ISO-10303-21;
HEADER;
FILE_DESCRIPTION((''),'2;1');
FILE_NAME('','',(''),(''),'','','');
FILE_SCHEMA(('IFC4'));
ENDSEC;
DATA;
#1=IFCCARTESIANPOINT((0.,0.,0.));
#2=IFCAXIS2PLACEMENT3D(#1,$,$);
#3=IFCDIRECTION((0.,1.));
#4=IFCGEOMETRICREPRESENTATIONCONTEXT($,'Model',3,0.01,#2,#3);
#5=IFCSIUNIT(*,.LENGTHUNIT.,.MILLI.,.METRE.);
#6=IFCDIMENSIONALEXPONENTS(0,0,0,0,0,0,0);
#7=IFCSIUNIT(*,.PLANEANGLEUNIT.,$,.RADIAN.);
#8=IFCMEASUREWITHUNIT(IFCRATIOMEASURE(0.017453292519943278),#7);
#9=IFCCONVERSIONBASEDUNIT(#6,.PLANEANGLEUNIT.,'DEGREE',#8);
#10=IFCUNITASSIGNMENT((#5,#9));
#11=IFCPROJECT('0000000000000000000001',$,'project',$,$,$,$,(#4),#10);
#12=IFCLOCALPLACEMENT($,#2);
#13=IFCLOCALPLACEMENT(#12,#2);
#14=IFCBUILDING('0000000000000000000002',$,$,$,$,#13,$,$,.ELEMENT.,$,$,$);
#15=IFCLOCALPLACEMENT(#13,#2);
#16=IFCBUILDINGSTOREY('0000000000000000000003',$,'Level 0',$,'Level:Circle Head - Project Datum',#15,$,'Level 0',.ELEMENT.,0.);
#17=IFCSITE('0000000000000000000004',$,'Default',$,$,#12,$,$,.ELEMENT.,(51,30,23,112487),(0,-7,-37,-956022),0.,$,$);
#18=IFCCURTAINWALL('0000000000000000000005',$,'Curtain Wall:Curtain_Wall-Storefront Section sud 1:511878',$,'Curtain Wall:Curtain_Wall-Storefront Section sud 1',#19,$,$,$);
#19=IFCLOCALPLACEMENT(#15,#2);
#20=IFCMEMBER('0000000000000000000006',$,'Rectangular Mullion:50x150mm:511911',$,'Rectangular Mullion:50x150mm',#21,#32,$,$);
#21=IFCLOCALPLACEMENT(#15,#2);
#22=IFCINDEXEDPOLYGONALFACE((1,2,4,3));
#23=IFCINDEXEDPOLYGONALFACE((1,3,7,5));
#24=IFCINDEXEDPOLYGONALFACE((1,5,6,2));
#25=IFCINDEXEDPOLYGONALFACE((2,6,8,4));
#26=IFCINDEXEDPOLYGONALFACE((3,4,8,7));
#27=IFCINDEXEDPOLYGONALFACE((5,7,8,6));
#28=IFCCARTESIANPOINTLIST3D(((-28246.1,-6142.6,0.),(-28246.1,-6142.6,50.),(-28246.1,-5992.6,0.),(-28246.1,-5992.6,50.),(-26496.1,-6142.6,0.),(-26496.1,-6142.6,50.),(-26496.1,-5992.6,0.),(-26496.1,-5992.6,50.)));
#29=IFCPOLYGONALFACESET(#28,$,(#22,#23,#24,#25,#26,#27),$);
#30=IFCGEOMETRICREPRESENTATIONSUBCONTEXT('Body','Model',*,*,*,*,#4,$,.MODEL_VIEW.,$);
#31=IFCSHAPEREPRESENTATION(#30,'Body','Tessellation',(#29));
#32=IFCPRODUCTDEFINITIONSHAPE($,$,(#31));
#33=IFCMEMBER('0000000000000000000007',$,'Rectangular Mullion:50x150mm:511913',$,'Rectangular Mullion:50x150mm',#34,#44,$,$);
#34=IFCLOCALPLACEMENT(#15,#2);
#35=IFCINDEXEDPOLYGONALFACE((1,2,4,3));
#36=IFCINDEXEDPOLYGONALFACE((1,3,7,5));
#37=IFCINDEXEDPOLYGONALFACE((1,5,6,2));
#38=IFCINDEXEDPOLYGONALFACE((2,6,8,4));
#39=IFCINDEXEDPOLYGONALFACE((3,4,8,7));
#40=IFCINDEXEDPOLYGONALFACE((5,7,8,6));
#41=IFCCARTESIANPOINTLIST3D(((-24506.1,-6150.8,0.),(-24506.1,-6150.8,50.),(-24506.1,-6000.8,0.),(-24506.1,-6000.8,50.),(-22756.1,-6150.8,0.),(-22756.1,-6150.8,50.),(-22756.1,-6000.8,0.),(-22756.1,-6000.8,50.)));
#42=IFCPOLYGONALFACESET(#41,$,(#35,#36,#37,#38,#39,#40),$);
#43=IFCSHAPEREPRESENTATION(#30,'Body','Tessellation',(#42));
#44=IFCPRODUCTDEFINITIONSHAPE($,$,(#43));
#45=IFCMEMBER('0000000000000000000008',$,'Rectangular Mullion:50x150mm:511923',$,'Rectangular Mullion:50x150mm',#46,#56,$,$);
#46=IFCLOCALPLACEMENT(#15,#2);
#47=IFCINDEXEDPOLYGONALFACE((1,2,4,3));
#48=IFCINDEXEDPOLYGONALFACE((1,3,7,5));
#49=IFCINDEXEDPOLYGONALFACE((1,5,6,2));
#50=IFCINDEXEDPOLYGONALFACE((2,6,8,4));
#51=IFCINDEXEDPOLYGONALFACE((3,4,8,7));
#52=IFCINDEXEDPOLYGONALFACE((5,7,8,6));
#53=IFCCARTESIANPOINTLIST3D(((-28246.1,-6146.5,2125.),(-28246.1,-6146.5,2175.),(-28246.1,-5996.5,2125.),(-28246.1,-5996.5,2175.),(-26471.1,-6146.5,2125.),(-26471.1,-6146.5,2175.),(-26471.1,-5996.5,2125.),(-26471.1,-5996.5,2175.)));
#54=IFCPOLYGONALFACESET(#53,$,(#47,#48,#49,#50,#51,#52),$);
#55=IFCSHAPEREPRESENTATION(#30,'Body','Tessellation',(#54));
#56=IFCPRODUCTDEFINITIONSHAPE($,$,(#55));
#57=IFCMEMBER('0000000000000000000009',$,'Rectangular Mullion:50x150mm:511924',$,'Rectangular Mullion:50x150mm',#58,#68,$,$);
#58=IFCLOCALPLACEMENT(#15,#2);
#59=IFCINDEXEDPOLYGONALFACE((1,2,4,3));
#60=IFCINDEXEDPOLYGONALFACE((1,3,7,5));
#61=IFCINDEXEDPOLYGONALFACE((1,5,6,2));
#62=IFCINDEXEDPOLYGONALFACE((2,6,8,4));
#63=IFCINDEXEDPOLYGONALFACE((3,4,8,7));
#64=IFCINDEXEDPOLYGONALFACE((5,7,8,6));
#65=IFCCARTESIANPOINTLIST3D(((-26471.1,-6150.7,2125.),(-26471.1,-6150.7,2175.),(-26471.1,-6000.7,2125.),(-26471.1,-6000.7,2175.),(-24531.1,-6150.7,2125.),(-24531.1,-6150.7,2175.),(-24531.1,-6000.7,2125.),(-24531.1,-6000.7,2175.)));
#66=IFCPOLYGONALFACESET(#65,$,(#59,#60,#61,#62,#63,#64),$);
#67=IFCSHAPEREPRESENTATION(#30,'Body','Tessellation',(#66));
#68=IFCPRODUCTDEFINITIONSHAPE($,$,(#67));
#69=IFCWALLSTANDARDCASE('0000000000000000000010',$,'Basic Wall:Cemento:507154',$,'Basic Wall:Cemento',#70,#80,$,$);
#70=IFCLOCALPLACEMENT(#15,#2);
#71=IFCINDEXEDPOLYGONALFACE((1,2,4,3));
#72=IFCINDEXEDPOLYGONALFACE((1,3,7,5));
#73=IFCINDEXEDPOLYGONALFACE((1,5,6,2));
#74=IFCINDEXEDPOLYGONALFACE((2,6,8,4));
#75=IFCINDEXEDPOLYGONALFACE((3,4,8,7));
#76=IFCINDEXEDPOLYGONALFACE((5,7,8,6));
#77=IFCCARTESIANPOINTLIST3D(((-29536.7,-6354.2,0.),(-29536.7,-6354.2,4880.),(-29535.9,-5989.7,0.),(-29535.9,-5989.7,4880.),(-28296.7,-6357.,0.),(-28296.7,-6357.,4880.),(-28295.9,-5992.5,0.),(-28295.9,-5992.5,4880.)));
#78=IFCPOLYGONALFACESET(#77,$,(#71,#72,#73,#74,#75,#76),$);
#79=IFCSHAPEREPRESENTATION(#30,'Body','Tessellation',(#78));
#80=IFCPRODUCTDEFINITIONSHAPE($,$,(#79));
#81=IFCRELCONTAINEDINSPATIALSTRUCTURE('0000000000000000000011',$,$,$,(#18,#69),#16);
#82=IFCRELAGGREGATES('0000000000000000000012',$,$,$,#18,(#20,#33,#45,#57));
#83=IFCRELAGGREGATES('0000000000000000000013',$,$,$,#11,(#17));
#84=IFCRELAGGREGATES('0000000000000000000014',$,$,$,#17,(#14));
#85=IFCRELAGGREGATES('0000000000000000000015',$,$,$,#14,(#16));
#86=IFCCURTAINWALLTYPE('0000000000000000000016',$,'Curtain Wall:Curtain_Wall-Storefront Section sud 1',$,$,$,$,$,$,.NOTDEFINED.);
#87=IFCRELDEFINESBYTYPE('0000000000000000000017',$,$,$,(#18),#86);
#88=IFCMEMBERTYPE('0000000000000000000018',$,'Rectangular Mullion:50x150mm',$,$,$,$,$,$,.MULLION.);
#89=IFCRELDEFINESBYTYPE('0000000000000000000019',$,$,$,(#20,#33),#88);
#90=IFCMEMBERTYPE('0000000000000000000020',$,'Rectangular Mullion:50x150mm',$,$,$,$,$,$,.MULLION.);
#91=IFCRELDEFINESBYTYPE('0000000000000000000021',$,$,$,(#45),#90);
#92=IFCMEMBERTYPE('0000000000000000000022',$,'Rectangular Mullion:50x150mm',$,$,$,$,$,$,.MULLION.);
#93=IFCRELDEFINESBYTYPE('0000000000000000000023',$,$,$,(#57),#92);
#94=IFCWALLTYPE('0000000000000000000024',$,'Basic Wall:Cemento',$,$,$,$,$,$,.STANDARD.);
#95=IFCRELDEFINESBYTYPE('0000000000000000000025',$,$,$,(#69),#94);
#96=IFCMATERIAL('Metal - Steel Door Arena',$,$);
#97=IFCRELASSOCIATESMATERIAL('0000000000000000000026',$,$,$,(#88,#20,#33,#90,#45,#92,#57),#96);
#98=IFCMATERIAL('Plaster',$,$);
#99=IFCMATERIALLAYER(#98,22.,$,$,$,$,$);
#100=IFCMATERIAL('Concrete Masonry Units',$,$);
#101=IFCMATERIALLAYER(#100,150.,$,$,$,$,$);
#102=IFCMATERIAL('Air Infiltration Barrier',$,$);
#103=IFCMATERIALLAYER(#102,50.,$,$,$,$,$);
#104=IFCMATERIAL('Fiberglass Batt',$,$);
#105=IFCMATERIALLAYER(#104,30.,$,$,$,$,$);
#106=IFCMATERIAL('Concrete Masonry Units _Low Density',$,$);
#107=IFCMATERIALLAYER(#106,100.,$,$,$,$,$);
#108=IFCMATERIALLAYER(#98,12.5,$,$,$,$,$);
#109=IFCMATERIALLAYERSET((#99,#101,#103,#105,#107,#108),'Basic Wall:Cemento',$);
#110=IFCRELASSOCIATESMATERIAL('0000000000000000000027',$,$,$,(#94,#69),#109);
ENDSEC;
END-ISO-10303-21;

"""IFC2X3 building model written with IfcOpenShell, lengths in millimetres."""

from ifc_helpers import new_model, entity, si_unit, converted_unit, direction, frame, frame_2d, origin, origin_2d_with_axis, place, context, subcontext, project, spatial, rectangle, extrude, source, transform, mapped, material, layer, layer_set, layer_usage, type_object, type_shapes, element, aggregate, save


model = new_model("IFC2X3")

# Units and contexts
model_context = context("Model", 3, precision=0.01, world=origin(), true_north=direction((0.0, 1.0)))
body_context = subcontext(model_context, "Body", "Model", "MODEL_VIEW")
ifc_project = project(units=[si_unit("LENGTHUNIT", "METRE", prefix="MILLI"), converted_unit("PLANEANGLEUNIT", "DEGREE", entity("IfcRatioMeasure", 0.017453292519943278), si_unit("PLANEANGLEUNIT", "RADIAN"), dimensions=[0, 0, 0, 0, 0, 0, 0])], contexts=[model_context])

# Site, building, storey
site_placement = place(None, origin())
site = spatial("IfcSite", under=ifc_project, at=site_placement, Name="Default", CompositionType="ELEMENT", RefLatitude=(51, 30, 23, 112487), RefLongitude=(0, -7, -37, -956022), RefElevation=0.0)
building_placement = place(site_placement, origin())
building = spatial("IfcBuilding", under=site, at=building_placement, CompositionType="ELEMENT")
storey_placement = place(building_placement, origin())
storey = spatial("IfcBuildingStorey", under=building, at=storey_placement, Name="Level 0", ObjectType="Level:Circle Head - Project Datum", LongName="Level 0", CompositionType="ELEMENT", Elevation=0.0)

# Shared definitions
curtain_wall_type = type_object("IfcCurtainWallType", Name="Curtain Wall:Curtain_Wall-Storefront Section sud 1", PredefinedType="NOTDEFINED")
ifc_material_1 = material(Name="Metal - Steel Door Arena")

# Curtain wall
curtain_wall_1_placement = place(storey_placement, origin())
curtain_wall_1 = element("IfcCurtainWall", 1, at=curtain_wall_1_placement, inside=storey, type_object=curtain_wall_type, Name="Curtain Wall:Curtain_Wall-Storefront Section sud 1:511878", ObjectType="Curtain Wall:Curtain_Wall-Storefront Section sud 1")

# Members
member_type_1 = type_object("IfcMemberType", Name="Rectangular Mullion:50x150mm", PredefinedType="MULLION", material=ifc_material_1)
shared_shape_1 = source(origin(), body_context, "Body", "SweptSolid", [
    extrude(rectangle(XDim=150.0, YDim=50.0, at=origin_2d_with_axis()), frame((-25.0, 0.0, -1750.0), z_axis=(0.0, 0.0, 1.0), x_axis=(0.0, -1.0, 0.0)), (0.0, 0.0, 1.0), 1750.0),
])
type_shapes(member_type_1, [shared_shape_1])
member_1_placement = place(curtain_wall_1_placement, frame((-28246.1, -6067.6, 0.0), z_axis=(-1.0, 0.0, 0.0), x_axis=(0.0, 0.0, -1.0)))
member_1 = element("IfcMember", 2, at=member_1_placement, type_object=member_type_1, material=ifc_material_1, Name="Rectangular Mullion:50x150mm:511911", ObjectType="Rectangular Mullion:50x150mm", context=body_context, shape_type="MappedRepresentation", body=[
    mapped(shared_shape_1, transform((0.0, 0.0, 0.0), scale=1.0)),
])
member_2_placement = place(curtain_wall_1_placement, frame((-24506.1, -6075.8, 0.0), z_axis=(-1.0, 0.0, 0.0), x_axis=(0.0, 0.0, -1.0)))
member_2 = element("IfcMember", 3, at=member_2_placement, type_object=member_type_1, material=ifc_material_1, Name="Rectangular Mullion:50x150mm:511913", ObjectType="Rectangular Mullion:50x150mm", context=body_context, shape_type="MappedRepresentation", body=[
    mapped(shared_shape_1, transform((0.0, 0.0, 0.0), scale=1.0)),
])
member_type_2 = type_object("IfcMemberType", Name="Rectangular Mullion:50x150mm", PredefinedType="MULLION", material=ifc_material_1)
shared_shape_2 = source(origin(), body_context, "Body", "SweptSolid", [
    extrude(rectangle(XDim=150.0, YDim=50.0, at=origin_2d_with_axis()), frame((0.0, 0.0, -1775.0), z_axis=(0.0, 0.0, 1.0), x_axis=(0.0, -1.0, 0.0)), (0.0, 0.0, 1.0), 1775.0),
])
type_shapes(member_type_2, [shared_shape_2])
member_3_placement = place(curtain_wall_1_placement, frame((-26471.1, -6071.5, 2150.0), z_axis=(1.0, 0.0, 0.0), x_axis=(0.0, 0.0, 1.0)))
member_3 = element("IfcMember", 4, at=member_3_placement, type_object=member_type_2, material=ifc_material_1, Name="Rectangular Mullion:50x150mm:511923", ObjectType="Rectangular Mullion:50x150mm", context=body_context, shape_type="MappedRepresentation", body=[
    mapped(shared_shape_2, transform((0.0, 0.0, 0.0), scale=1.0)),
])
member_type_3 = type_object("IfcMemberType", Name="Rectangular Mullion:50x150mm", PredefinedType="MULLION", material=ifc_material_1)
shared_shape_3 = source(origin(), body_context, "Body", "SweptSolid", [
    extrude(rectangle(XDim=150.0, YDim=50.0, at=origin_2d_with_axis()), frame((0.0, 0.0, -1940.0), z_axis=(0.0, 0.0, 1.0), x_axis=(0.0, -1.0, 0.0)), (0.0, 0.0, 1.0), 1940.0),
])
type_shapes(member_type_3, [shared_shape_3])
member_4_placement = place(curtain_wall_1_placement, frame((-24531.1, -6075.7, 2150.0), z_axis=(1.0, 0.0, 0.0), x_axis=(0.0, 0.0, 1.0)))
member_4 = element("IfcMember", 5, at=member_4_placement, type_object=member_type_3, material=ifc_material_1, Name="Rectangular Mullion:50x150mm:511924", ObjectType="Rectangular Mullion:50x150mm", context=body_context, shape_type="MappedRepresentation", body=[
    mapped(shared_shape_3, transform((0.0, 0.0, 0.0), scale=1.0)),
])

aggregate(curtain_wall_1, [member_1, member_2, member_3, member_4])

# Wall
ifc_material_2 = material(Name="Plaster")
ifc_layer_1 = layer(ifc_material_2, 22.0)
ifc_material_3 = material(Name="Concrete Masonry Units")
ifc_layer_2 = layer(ifc_material_3, 150.0)
ifc_material_4 = material(Name="Air Infiltration Barrier")
ifc_layer_3 = layer(ifc_material_4, 50.0)
ifc_material_5 = material(Name="Fiberglass Batt")
ifc_layer_4 = layer(ifc_material_5, 30.0)
ifc_material_6 = material(Name="Concrete Masonry Units _Low Density")
ifc_layer_5 = layer(ifc_material_6, 100.0)
ifc_layer_6 = layer(ifc_material_2, 12.5)
ifc_layer_set = layer_set([ifc_layer_1, ifc_layer_2, ifc_layer_3, ifc_layer_4, ifc_layer_5, ifc_layer_6], Name="Basic Wall:Cemento")
ifc_layer_usage = layer_usage(ifc_layer_set, "AXIS2", "NEGATIVE", 182.3)
wall_type = type_object("IfcWallType", Name="Basic Wall:Cemento", PredefinedType="STANDARD", material=ifc_layer_set)
wall_placement = place(storey_placement, frame((-28296.3, -6174.7, 0.0), z_axis=(0.0, 0.0, 1.0), x_axis=(-0.999998, 0.002199, 0.0)))
element("IfcWallStandardCase", 6, at=wall_placement, inside=storey, type_object=wall_type, material=ifc_layer_usage, Name="Basic Wall:Cemento:507154", ObjectType="Basic Wall:Cemento", context=body_context, shape_type="SweptSolid", body=[
    extrude(rectangle(XDim=1240.0, YDim=364.5, at=frame_2d((620.0, 0.0), x_axis=(-1.0, 0.0))), origin(), (0.0, 0.0, 1.0), 4880.0),
])

save(model, "model.ifc")
